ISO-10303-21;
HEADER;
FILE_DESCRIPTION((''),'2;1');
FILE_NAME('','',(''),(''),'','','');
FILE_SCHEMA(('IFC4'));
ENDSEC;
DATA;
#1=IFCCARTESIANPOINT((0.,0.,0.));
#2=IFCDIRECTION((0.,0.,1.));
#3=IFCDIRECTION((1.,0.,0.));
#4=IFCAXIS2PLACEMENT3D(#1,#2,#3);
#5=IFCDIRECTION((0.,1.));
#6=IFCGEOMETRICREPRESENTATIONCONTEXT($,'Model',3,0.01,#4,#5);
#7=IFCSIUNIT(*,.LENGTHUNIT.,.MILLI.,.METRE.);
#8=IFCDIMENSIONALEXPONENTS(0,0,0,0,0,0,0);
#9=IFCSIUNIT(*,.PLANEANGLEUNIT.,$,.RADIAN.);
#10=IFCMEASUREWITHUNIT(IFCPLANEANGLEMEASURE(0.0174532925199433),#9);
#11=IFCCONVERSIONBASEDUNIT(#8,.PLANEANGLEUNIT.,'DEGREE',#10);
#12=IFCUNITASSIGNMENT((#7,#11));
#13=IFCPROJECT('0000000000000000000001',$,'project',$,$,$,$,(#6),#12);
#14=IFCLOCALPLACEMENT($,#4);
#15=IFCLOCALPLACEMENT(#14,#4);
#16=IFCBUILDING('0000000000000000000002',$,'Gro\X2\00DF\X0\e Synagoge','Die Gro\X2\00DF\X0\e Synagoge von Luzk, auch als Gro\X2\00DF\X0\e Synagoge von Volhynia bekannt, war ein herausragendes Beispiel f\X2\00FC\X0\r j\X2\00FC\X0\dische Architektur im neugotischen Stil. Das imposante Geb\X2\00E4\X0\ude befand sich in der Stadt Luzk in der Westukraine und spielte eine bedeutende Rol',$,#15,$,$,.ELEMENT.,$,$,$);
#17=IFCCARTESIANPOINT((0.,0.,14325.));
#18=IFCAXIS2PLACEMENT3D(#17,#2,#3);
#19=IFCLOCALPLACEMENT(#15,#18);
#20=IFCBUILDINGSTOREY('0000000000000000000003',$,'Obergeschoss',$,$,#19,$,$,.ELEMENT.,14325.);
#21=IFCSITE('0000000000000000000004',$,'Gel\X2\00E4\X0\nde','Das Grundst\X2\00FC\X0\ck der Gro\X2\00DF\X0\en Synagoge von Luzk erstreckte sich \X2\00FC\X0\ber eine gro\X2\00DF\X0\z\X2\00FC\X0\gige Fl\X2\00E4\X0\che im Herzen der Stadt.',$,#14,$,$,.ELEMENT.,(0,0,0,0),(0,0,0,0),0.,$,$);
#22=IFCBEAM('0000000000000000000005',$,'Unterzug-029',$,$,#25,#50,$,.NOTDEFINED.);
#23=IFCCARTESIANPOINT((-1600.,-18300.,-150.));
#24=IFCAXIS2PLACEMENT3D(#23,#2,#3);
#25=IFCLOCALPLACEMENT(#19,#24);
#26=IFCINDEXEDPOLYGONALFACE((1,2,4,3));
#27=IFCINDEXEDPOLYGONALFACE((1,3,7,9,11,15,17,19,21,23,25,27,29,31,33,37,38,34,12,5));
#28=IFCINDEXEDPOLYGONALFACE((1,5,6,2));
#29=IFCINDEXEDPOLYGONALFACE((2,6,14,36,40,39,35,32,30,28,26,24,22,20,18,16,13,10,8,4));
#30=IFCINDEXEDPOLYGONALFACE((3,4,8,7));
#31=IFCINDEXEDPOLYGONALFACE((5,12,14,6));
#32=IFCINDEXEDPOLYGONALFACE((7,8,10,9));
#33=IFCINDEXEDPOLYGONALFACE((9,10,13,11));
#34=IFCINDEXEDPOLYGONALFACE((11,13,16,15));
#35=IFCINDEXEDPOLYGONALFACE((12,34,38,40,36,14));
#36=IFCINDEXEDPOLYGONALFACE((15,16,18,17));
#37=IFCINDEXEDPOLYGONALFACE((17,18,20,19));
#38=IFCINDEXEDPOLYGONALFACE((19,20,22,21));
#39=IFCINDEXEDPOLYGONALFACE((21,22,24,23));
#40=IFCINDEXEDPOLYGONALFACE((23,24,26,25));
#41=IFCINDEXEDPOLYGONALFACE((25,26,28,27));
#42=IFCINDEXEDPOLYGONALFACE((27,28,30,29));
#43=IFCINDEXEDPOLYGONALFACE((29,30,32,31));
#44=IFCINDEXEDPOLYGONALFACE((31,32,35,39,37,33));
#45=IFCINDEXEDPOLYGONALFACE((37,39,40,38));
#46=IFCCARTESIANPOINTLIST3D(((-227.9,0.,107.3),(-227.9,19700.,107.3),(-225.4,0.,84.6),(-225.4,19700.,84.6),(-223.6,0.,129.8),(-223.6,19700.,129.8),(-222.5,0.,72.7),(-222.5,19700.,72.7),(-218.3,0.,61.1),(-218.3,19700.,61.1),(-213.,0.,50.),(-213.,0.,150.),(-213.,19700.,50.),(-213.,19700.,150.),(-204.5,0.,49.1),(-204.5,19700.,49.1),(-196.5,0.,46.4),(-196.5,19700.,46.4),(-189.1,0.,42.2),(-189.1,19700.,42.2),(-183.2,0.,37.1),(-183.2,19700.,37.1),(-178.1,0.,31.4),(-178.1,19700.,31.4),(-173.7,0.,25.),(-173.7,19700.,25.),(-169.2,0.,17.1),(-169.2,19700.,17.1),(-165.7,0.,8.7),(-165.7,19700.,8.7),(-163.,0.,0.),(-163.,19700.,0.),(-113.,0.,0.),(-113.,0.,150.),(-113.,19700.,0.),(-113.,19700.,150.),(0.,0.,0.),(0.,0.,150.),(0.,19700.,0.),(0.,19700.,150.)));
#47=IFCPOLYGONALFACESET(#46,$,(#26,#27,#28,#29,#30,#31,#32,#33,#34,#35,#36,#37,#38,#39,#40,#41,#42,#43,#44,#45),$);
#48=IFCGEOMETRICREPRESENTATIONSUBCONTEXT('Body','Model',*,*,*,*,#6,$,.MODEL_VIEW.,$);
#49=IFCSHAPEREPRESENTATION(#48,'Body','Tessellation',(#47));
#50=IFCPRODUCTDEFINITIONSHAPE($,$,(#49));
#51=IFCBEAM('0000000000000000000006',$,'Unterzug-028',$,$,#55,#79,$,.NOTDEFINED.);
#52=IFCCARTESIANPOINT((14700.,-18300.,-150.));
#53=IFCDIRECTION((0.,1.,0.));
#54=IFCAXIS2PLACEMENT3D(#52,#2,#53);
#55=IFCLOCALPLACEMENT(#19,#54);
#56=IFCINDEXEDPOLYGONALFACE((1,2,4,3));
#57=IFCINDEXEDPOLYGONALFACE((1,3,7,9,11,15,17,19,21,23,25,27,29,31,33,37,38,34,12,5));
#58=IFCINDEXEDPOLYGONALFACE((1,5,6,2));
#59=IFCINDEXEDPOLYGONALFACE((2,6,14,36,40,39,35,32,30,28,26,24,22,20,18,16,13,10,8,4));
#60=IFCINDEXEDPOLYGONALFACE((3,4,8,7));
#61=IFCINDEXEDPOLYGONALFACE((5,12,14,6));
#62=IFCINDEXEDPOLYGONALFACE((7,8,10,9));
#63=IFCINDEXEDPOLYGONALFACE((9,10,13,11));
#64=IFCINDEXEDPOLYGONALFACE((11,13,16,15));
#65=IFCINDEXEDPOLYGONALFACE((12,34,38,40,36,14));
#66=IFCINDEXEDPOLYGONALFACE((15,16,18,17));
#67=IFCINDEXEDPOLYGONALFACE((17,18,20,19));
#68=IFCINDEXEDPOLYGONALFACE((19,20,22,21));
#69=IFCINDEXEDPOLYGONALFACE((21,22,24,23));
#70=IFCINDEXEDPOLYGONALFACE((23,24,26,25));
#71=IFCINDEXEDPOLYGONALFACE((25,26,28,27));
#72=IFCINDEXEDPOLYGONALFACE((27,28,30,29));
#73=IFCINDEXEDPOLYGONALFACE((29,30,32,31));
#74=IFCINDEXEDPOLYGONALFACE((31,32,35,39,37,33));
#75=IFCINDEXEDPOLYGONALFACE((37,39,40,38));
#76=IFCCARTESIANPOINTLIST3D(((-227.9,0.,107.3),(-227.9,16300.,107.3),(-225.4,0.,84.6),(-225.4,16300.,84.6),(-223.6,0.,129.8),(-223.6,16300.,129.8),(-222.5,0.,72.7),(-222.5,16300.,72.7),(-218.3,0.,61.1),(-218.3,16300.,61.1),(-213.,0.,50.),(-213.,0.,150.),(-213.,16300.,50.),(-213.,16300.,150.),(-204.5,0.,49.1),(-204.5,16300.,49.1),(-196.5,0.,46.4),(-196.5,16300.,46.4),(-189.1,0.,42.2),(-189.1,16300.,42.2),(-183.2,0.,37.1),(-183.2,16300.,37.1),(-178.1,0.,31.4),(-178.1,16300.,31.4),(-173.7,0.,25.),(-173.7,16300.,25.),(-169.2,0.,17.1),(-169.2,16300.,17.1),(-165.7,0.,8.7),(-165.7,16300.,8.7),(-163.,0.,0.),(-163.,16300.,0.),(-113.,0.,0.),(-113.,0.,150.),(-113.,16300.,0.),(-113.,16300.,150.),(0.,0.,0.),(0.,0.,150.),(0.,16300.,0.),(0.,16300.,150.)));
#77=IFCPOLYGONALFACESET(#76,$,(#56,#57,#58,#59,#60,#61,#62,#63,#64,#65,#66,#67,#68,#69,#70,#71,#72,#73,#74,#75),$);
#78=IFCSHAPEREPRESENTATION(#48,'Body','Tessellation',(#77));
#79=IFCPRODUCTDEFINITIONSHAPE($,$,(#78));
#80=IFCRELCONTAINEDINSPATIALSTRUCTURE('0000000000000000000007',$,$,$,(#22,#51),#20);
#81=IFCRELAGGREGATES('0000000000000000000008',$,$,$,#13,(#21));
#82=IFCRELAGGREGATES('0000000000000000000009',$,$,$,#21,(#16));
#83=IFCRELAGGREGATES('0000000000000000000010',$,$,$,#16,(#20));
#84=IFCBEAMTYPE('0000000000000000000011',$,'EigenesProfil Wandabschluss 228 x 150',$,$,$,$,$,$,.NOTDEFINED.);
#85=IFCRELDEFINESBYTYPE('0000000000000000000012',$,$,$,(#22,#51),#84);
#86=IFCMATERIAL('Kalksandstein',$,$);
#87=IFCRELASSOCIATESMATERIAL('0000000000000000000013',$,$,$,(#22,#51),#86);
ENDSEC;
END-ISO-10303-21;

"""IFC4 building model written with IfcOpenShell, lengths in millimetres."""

from ifc_helpers import new_model, entity, si_unit, converted_unit, direction, frame, origin_with_axes, place, context, subcontext, project, spatial, line, arc, indexed_curve, outline, extrude, material, material_profile, profile_set, type_object, element, save


model = new_model("IFC4")

# Units and contexts
model_context = context("Model", 3, precision=0.01, world=origin_with_axes(), true_north=direction((0.0, 1.0)))
body_context = subcontext(model_context, "Body", "Model", "MODEL_VIEW")
ifc_project = project(units=[si_unit("LENGTHUNIT", "METRE", prefix="MILLI"), converted_unit("PLANEANGLEUNIT", "DEGREE", entity("IfcPlaneAngleMeasure", 0.0174532925199433), si_unit("PLANEANGLEUNIT", "RADIAN"), dimensions=[0, 0, 0, 0, 0, 0, 0])], contexts=[model_context])

# Site, building, storey
site_placement = place(None, origin_with_axes())
site = spatial("IfcSite", under=ifc_project, at=site_placement, Name="Gelände", Description="Das Grundstück der Großen Synagoge von Luzk erstreckte sich über eine großzügige Fläche im Herzen der Stadt.", CompositionType="ELEMENT", RefLatitude=(0, 0, 0, 0), RefLongitude=(0, 0, 0, 0), RefElevation=0.0)
building_placement = place(site_placement, origin_with_axes())
building = spatial("IfcBuilding", under=site, at=building_placement, Name="Große Synagoge", Description="Die Große Synagoge von Luzk, auch als Große Synagoge von Volhynia bekannt, war ein herausragendes Beispiel für jüdische Architektur im neugotischen Stil. Das imposante Gebäude befand sich in der Stadt Luzk in der Westukraine und spielte eine bedeutende Rol", CompositionType="ELEMENT")
storey_placement = place(building_placement, frame((0.0, 0.0, 14325.0), z_axis=(0.0, 0.0, 1.0), x_axis=(1.0, 0.0, 0.0)))
storey = spatial("IfcBuildingStorey", under=building, at=storey_placement, Name="Obergeschoss", CompositionType="ELEMENT", Elevation=14325.0)

# Beams
ifc_material_1 = material(Name="Kalksandstein")
ifc_material_profile_1 = material_profile(ifc_material_1, outline(indexed_curve([(0.0, 150.0), (0.0, 0.0), (113.0, 0.0), (163.0, 0.0), (167.3, 12.9), (173.7, 25.0), (180.6, 34.3), (189.1, 42.2), (200.4, 48.0), (213.0, 50.0), (220.6, 66.8), (225.4, 84.6), (226.6, 118.7), (213.0, 150.0), (113.0, 150.0)], segments=[line(1, 2, 3, 4), arc(4, 5, 6), arc(6, 7, 8), arc(8, 9, 10), arc(10, 11, 12), arc(12, 13, 14), line(14, 15, 1)])), Name="Kalksandstein")
ifc_profile_set_1 = profile_set([ifc_material_profile_1], Name="EigenesProfil Wandabschluss")
beam_type_1 = type_object("IfcBeamType", Name="EigenesProfil Wandabschluss 228 x 150", PredefinedType="NOTDEFINED")
beam_1_placement = place(storey_placement, frame((-1600.0, -18300.0, -150.0), z_axis=(0.0, 0.0, 1.0), x_axis=(1.0, 0.0, 0.0)))
element("IfcBeam", 1, at=beam_1_placement, inside=storey, type_object=beam_type_1, material=ifc_profile_set_1, Name="Unterzug-029", PredefinedType="NOTDEFINED", context=body_context, shape_type="SweptSolid", body=[
    extrude(outline(indexed_curve([(0.0, 150.0), (0.0, 0.0), (113.0, 0.0), (163.0, 0.0), (167.3, 12.9), (173.7, 25.0), (180.6, 34.3), (189.1, 42.2), (200.4, 48.0), (213.0, 50.0), (220.6, 66.8), (225.4, 84.6), (226.6, 118.7), (213.0, 150.0), (113.0, 150.0)], segments=[line(1, 2, 3, 4), arc(4, 5, 6), arc(6, 7, 8), arc(8, 9, 10), arc(10, 11, 12), arc(12, 13, 14), line(14, 15, 1)])), frame((0.0, 19700.0, 0.0), z_axis=(0.0, 1.0, 0.0), x_axis=(-1.0, 0.0, 0.0)), (0.0, 0.0, -1.0), 19700.0),
])
beam_2_placement = place(storey_placement, frame((14700.0, -18300.0, -150.0), z_axis=(0.0, 0.0, 1.0), x_axis=(0.0, 1.0, 0.0)))
element("IfcBeam", 2, at=beam_2_placement, inside=storey, type_object=beam_type_1, material=ifc_profile_set_1, Name="Unterzug-028", PredefinedType="NOTDEFINED", context=body_context, shape_type="SweptSolid", body=[
    extrude(outline(indexed_curve([(0.0, 150.0), (0.0, 0.0), (113.0, 0.0), (163.0, 0.0), (167.3, 12.9), (173.7, 25.0), (180.6, 34.3), (189.1, 42.2), (200.4, 48.0), (213.0, 50.0), (220.6, 66.8), (225.4, 84.6), (226.6, 118.7), (213.0, 150.0), (113.0, 150.0)], segments=[line(1, 2, 3, 4), arc(4, 5, 6), arc(6, 7, 8), arc(8, 9, 10), arc(10, 11, 12), arc(12, 13, 14), line(14, 15, 1)])), frame((0.0, 16300.0, 0.0), z_axis=(0.0, 1.0, 0.0), x_axis=(-1.0, 0.0, 0.0)), (0.0, 0.0, -1.0), 16300.0),
])

save(model, "model.ifc")
